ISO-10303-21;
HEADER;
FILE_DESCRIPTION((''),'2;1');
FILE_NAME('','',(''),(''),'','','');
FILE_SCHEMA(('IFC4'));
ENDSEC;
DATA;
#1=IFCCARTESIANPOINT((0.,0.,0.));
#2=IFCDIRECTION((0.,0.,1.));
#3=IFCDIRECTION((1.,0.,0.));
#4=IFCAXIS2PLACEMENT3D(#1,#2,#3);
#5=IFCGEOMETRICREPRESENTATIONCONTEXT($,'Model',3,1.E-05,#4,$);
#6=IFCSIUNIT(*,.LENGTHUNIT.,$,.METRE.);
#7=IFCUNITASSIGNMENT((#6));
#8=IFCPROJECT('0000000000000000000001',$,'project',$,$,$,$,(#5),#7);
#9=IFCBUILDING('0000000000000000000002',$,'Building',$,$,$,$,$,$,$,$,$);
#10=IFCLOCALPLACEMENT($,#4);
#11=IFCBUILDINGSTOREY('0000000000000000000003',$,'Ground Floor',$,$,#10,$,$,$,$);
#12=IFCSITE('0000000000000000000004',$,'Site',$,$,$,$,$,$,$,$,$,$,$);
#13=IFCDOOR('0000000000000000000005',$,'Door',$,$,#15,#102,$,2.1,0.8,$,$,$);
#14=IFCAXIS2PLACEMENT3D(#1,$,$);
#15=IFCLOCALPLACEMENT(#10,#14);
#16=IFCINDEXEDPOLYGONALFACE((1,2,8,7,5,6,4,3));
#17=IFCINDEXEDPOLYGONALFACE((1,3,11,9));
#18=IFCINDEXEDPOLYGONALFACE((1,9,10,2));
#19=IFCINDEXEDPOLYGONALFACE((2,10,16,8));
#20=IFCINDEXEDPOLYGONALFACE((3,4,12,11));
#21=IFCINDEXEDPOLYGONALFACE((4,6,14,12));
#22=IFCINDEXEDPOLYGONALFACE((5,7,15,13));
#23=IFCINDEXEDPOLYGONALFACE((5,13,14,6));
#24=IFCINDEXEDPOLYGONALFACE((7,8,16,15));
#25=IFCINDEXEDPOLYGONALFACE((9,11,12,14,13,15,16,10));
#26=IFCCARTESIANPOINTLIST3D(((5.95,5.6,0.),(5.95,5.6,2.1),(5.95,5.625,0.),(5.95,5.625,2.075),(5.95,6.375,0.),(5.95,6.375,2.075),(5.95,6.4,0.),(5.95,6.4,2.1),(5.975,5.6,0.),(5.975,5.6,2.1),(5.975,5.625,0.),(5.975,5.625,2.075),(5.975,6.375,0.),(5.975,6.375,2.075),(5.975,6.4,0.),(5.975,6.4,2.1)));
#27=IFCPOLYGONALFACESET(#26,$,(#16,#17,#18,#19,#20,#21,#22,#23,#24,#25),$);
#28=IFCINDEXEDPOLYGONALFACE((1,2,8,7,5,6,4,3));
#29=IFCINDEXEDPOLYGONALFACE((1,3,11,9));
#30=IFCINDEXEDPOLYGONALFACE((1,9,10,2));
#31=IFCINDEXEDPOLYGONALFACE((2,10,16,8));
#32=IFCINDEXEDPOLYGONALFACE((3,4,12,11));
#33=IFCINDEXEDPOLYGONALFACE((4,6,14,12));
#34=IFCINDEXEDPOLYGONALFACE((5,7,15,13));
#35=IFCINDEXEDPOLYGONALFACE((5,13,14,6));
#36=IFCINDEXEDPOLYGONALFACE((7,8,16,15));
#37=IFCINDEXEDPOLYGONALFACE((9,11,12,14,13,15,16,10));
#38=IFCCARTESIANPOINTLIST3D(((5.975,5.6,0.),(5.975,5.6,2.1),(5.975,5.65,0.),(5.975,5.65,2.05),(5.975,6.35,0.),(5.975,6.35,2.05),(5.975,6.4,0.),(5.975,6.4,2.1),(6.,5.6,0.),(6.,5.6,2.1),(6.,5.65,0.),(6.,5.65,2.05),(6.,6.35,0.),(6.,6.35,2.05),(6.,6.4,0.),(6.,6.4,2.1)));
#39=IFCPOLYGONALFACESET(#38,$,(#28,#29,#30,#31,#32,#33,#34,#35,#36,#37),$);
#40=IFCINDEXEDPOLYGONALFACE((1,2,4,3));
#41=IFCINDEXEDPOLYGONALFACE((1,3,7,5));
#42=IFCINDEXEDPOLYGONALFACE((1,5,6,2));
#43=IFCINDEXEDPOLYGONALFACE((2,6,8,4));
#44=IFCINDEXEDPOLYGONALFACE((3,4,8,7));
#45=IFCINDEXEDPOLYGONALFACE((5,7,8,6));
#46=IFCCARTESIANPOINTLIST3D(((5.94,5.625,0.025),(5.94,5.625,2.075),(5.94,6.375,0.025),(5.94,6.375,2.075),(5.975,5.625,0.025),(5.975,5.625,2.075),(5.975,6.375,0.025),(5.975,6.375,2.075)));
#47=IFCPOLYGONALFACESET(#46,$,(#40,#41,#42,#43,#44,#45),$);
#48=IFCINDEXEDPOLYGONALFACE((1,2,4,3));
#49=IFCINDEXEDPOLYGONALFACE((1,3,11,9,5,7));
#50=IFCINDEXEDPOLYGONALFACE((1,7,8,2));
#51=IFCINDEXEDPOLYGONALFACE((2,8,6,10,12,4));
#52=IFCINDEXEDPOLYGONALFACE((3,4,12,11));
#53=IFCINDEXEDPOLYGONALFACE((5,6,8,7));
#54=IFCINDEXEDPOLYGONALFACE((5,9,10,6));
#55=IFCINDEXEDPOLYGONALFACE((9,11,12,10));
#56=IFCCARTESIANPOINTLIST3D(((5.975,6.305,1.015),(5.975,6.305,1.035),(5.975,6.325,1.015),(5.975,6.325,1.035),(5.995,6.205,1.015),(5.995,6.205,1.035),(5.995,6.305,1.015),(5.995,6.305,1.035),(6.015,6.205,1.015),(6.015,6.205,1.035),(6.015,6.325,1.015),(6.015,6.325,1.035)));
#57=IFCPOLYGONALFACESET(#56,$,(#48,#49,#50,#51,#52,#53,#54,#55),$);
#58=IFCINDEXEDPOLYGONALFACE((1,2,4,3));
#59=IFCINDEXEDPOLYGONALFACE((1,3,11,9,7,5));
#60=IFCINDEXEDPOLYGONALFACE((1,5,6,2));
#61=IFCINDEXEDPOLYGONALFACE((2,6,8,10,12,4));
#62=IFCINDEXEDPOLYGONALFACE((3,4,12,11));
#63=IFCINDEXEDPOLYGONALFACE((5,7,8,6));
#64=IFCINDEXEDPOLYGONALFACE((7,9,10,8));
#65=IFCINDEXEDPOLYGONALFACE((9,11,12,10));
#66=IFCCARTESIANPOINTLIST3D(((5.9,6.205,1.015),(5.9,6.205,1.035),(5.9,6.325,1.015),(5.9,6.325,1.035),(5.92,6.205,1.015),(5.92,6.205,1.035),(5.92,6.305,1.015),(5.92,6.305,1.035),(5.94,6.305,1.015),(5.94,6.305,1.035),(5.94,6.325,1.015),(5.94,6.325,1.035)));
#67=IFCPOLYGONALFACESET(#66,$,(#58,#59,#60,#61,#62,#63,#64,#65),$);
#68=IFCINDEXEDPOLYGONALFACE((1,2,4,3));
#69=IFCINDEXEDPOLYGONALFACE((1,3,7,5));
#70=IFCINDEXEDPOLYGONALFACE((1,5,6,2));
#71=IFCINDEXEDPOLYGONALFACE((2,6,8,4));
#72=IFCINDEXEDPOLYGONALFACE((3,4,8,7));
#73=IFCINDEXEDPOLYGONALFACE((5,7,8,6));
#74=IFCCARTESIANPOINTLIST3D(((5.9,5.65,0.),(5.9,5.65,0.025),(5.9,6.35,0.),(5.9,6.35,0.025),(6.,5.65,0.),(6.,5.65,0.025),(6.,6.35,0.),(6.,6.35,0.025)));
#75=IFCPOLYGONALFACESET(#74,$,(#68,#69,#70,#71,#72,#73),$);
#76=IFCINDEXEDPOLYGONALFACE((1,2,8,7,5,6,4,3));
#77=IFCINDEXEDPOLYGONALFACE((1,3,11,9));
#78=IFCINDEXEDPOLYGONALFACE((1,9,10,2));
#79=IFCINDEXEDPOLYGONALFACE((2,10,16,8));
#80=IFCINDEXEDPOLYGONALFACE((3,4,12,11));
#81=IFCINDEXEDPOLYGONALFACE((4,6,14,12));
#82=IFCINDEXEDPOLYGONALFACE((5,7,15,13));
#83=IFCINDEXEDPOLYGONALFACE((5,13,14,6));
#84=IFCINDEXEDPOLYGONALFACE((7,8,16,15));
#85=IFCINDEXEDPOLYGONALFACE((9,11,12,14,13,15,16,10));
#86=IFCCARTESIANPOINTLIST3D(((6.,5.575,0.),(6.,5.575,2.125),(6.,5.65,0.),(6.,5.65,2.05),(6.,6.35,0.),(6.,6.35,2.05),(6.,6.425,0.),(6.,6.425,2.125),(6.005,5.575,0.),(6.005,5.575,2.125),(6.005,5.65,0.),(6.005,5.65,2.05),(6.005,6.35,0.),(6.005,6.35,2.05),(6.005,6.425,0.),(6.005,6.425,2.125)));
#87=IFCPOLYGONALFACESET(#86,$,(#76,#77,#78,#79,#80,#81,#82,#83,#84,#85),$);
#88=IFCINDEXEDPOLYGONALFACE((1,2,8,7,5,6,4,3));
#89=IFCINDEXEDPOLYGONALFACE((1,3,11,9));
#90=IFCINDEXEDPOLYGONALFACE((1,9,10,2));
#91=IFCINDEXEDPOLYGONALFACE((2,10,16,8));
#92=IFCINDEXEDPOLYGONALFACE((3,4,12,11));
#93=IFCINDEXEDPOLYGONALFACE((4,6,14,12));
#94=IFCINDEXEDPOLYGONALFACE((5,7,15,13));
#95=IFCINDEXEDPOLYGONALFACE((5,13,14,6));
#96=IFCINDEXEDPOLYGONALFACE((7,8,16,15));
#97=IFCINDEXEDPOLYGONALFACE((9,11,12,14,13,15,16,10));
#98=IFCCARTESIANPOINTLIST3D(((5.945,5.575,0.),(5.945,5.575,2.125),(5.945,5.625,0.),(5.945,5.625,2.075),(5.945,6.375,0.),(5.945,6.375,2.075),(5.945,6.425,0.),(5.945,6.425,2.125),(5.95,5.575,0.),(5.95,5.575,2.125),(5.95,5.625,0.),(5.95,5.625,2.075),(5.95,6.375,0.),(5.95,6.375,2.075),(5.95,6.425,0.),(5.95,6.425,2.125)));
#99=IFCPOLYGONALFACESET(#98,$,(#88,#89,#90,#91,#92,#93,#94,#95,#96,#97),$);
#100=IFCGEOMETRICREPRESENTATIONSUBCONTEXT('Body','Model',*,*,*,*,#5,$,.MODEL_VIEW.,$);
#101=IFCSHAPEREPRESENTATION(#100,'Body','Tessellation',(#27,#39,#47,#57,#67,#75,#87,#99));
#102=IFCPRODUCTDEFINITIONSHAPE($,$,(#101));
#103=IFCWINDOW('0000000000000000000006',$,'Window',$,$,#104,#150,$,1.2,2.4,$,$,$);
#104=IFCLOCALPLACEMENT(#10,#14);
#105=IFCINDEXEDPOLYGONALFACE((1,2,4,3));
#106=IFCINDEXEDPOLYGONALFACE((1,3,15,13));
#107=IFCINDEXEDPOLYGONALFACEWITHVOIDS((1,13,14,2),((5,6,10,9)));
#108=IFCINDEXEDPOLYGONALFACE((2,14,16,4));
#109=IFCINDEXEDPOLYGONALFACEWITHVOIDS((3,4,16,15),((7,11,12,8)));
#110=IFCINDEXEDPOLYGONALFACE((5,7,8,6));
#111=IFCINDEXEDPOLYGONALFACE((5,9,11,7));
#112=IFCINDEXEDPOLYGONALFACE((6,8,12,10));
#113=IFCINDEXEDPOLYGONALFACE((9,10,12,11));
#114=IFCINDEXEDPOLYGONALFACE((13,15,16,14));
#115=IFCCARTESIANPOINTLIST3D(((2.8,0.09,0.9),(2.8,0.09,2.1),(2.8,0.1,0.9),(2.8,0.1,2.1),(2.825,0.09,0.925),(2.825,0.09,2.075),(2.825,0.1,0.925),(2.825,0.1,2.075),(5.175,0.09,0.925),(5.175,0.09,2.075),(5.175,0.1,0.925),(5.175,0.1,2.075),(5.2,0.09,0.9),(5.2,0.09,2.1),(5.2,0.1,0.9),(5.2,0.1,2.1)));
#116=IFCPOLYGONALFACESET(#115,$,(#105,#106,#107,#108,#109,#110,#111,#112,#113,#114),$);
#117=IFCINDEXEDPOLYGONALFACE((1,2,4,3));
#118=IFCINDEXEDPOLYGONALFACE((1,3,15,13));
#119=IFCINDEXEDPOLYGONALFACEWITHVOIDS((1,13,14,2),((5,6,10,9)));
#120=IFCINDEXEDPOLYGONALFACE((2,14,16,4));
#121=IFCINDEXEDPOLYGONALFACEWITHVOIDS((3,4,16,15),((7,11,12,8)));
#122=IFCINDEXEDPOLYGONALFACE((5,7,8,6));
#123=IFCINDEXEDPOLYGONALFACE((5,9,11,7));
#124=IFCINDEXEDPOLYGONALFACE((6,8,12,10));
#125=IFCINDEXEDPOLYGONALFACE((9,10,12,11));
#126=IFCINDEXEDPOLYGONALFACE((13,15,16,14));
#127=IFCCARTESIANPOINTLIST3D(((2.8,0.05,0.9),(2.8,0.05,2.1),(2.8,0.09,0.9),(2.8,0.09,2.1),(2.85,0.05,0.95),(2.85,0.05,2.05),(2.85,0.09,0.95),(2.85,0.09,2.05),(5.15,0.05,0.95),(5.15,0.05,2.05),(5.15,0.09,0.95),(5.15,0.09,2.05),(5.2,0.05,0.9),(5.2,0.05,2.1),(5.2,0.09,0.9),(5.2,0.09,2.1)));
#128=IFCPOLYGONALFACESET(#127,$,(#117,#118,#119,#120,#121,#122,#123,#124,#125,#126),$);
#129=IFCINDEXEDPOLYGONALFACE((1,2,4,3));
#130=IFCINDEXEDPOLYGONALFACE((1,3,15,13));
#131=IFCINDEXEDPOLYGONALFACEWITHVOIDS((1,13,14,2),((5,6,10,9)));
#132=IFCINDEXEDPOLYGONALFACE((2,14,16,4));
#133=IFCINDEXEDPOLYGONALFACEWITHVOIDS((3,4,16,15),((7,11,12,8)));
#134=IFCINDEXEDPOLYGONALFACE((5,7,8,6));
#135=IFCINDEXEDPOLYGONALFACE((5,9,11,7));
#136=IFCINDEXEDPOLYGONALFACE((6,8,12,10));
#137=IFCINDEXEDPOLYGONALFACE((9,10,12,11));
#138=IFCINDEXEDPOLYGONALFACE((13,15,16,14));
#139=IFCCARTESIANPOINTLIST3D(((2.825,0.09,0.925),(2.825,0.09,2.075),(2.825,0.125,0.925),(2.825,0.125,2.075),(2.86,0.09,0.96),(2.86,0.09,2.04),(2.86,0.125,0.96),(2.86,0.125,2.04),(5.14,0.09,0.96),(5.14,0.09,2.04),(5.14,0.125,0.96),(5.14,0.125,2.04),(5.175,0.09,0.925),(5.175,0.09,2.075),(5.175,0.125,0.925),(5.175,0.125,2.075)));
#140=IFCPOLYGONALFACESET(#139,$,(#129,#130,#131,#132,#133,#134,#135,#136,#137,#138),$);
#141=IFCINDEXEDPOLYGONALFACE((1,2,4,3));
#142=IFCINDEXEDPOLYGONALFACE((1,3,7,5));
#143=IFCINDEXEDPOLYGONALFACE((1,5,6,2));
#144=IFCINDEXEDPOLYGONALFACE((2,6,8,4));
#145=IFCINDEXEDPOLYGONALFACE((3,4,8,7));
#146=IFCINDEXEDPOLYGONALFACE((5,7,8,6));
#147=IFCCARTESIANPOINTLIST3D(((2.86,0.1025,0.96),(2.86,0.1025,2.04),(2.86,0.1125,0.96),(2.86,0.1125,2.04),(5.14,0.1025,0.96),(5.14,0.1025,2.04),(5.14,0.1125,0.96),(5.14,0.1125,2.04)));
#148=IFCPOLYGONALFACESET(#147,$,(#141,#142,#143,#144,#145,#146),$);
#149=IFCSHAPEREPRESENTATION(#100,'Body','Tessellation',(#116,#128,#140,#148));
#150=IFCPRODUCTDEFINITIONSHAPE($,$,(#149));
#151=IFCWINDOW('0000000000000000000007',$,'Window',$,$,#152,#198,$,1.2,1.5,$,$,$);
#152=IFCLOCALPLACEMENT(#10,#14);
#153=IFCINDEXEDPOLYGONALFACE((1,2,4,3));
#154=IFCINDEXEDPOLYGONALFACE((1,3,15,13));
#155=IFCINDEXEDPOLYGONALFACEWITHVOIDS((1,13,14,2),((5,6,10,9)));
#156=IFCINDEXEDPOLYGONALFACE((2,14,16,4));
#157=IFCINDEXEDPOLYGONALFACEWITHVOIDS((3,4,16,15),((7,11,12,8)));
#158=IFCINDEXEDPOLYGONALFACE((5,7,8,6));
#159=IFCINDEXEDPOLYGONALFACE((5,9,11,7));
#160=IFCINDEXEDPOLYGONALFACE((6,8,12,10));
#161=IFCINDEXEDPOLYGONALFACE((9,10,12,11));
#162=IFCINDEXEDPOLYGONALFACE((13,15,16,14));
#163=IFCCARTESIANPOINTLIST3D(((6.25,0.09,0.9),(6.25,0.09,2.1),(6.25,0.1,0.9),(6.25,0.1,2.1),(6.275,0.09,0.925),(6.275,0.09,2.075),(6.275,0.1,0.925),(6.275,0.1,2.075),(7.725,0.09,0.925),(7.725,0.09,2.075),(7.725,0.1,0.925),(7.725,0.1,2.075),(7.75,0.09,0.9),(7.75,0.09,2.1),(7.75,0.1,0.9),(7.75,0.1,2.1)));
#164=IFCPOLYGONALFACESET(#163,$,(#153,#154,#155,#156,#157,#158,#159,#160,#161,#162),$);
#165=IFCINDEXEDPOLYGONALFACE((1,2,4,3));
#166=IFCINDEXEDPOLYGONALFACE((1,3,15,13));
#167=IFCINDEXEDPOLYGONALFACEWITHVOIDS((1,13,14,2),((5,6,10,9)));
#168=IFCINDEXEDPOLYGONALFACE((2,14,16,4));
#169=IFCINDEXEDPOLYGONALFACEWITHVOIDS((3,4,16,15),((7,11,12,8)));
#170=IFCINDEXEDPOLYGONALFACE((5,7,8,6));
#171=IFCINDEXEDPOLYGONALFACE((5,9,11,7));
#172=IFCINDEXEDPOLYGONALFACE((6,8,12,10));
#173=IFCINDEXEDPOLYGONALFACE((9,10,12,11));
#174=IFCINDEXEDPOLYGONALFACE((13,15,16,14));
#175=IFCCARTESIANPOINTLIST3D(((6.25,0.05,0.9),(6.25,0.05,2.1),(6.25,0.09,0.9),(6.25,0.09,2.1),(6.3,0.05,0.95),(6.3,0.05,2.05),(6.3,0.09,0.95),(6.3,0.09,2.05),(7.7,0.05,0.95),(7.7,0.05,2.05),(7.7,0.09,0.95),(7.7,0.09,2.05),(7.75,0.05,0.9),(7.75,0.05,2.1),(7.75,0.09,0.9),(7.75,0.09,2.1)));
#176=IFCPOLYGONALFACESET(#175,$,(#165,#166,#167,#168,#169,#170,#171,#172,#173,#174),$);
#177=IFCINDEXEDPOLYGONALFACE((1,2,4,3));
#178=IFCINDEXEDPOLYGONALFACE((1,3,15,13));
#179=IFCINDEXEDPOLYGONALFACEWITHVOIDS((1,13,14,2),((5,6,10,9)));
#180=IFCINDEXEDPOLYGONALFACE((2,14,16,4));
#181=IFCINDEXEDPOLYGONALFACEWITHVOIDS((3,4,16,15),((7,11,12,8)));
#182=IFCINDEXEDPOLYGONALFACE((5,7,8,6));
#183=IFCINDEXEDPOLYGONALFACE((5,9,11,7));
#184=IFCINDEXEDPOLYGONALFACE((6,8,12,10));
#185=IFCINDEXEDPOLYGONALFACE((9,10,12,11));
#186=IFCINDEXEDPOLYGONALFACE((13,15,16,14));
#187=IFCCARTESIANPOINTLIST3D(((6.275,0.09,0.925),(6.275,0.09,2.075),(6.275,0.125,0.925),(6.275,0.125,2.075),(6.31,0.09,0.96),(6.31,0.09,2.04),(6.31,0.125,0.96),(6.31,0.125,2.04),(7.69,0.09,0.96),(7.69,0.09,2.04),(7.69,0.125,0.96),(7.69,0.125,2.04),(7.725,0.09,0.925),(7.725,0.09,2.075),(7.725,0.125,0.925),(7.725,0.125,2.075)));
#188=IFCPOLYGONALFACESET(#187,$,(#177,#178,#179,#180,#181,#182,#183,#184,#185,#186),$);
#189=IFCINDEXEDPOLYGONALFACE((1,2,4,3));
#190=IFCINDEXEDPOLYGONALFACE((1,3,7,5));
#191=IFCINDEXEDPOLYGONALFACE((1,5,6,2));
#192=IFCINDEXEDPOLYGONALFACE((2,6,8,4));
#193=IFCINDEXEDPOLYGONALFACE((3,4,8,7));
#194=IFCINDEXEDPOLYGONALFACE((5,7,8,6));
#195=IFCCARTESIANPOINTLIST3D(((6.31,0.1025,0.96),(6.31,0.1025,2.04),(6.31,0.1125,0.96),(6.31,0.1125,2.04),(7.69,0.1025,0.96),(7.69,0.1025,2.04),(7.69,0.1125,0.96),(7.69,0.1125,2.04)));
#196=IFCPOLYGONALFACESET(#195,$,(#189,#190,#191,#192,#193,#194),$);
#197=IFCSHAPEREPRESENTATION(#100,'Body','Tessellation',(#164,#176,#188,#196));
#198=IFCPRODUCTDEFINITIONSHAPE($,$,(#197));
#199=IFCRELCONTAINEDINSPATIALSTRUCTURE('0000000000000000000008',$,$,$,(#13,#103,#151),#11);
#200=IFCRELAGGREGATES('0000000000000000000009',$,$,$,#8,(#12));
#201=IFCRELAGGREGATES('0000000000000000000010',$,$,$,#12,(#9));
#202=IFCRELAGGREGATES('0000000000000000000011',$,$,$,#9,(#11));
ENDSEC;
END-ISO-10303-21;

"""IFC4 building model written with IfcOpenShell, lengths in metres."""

from ifc_helpers import new_model, si_unit, frame, origin_with_axes, place, context, subcontext, project, spatial, line, indexed_curve, outline, extrude, element, save


model = new_model("IFC4")

# Units and contexts
model_context = context("Model", 3, precision=1e-05, world=origin_with_axes())
body_context = subcontext(model_context, "Body", "Model", "MODEL_VIEW")
ifc_project = project(units=[si_unit("LENGTHUNIT", "METRE")], contexts=[model_context])

# Site, building, storey
site = spatial("IfcSite", under=ifc_project, Name="Site")
building = spatial("IfcBuilding", under=site, Name="Building")
storey_placement = place(None, origin_with_axes())
storey = spatial("IfcBuildingStorey", under=building, at=storey_placement, Name="Ground Floor")

# Door
door_1_placement = place(storey_placement, frame((6.0, 5.6, 0.0), z_axis=(0.0, 0.0, 1.0), x_axis=(0.0, 1.0, 0.0)))
element("IfcDoor", 1, at=door_1_placement, inside=storey, Name="Door", OverallHeight=2.1, OverallWidth=0.8, context=body_context, shape_type="SweptSolid", body=[
    extrude(outline(indexed_curve([(0.0, 0.0), (0.0, 2.1), (0.8, 2.1), (0.8, 0.0), (0.775, 0.0), (0.775, 2.075), (0.025, 2.075), (0.025, 0.0)], segments=[line(1, 2, 3, 4, 5, 6, 7, 8, 1)])), frame((0.0, 0.025, 0.0), z_axis=(0.0, -1.0, 0.0), x_axis=(1.0, 0.0, 0.0)), (0.0, 0.0, -1.0), 0.025),
    extrude(outline(indexed_curve([(0.0, 0.0), (0.0, 2.1), (0.8, 2.1), (0.8, 0.0), (0.75, 0.0), (0.75, 2.05), (0.05, 2.05), (0.05, 0.0)], segments=[line(1, 2, 3, 4, 5, 6, 7, 8, 1)])), frame((0.0, 0.0, 0.0), z_axis=(0.0, -1.0, 0.0), x_axis=(1.0, 0.0, 0.0)), (0.0, 0.0, -1.0), 0.025),
    extrude(outline(indexed_curve([(0.0, 0.0), (0.75, 0.0), (0.75, 0.035), (0.0, 0.035)], segments=[line(1, 2, 3, 4, 1)])), frame((0.025, 0.025, 0.025), z_axis=(0.0, 0.0, 1.0), x_axis=(1.0, 0.0, 0.0)), (0.0, 0.0, 1.0), 2.05),
    extrude(outline(indexed_curve([(0.0, 0.0), (0.0, -0.04), (-0.12, -0.04), (-0.12, -0.02), (-0.02, -0.02), (-0.02, 0.0)], segments=[line(1, 2, 3, 4, 5, 6, 1)])), frame((0.725, 0.025, 1.015), z_axis=(0.0, 0.0, 1.0), x_axis=(1.0, 0.0, 0.0)), (0.0, 0.0, 1.0), 0.02),
    extrude(outline(indexed_curve([(0.0, 0.0), (0.0, 0.04), (-0.12, 0.04), (-0.12, 0.02), (-0.02, 0.02), (-0.02, 0.0)], segments=[line(1, 2, 3, 4, 5, 6, 1)])), frame((0.725, 0.06, 1.015), z_axis=(0.0, 0.0, 1.0), x_axis=(1.0, 0.0, 0.0)), (0.0, 0.0, 1.0), 0.02),
    extrude(outline(indexed_curve([(0.0, 0.0), (0.7, 0.0), (0.7, 0.1), (0.0, 0.1)], segments=[line(1, 2, 3, 4, 1)])), frame((0.05, 0.0, 0.0), z_axis=(0.0, 0.0, 1.0), x_axis=(1.0, 0.0, 0.0)), (0.0, 0.0, 1.0), 0.025),
    extrude(outline(indexed_curve([(0.0, 0.0), (0.0, 2.125), (0.85, 2.125), (0.85, 0.0), (0.775, 0.0), (0.775, 2.05), (0.075, 2.05), (0.075, 0.0)], segments=[line(1, 2, 3, 4, 5, 6, 7, 8, 1)])), frame((-0.025, -0.005, 0.0), z_axis=(0.0, -1.0, 0.0), x_axis=(1.0, 0.0, 0.0)), (0.0, 0.0, -1.0), 0.005),
    extrude(outline(indexed_curve([(0.0, 0.0), (0.0, 2.125), (0.85, 2.125), (0.85, 0.0), (0.8, 0.0), (0.8, 2.075), (0.05, 2.075), (0.05, 0.0)], segments=[line(1, 2, 3, 4, 5, 6, 7, 8, 1)])), frame((-0.025, 0.05, 0.0), z_axis=(0.0, -1.0, 0.0), x_axis=(1.0, 0.0, 0.0)), (0.0, 0.0, -1.0), 0.005),
])

# Windows
window_1_placement = place(storey_placement, frame((2.8, 0.0, 0.9), z_axis=(0.0, 0.0, 1.0), x_axis=(1.0, 0.0, 0.0)))
element("IfcWindow", 2, at=window_1_placement, inside=storey, Name="Window", OverallHeight=1.2, OverallWidth=2.4, context=body_context, shape_type="SweptSolid", body=[
    extrude(outline(indexed_curve([(0.0, 0.0), (2.4, 0.0), (2.4, 1.2), (0.0, 1.2)], segments=[line(1, 2, 3, 4, 1)]), holes=[indexed_curve([(0.025, 0.025), (2.375, 0.025), (2.375, 1.175), (0.025, 1.175)], segments=[line(1, 2, 3, 4, 1)])]), frame((0.0, 0.09, 0.0), z_axis=(0.0, -1.0, 0.0), x_axis=(1.0, 0.0, 0.0)), (0.0, 0.0, -1.0), 0.01),
    extrude(outline(indexed_curve([(0.0, 0.0), (2.4, 0.0), (2.4, 1.2), (0.0, 1.2)], segments=[line(1, 2, 3, 4, 1)]), holes=[indexed_curve([(0.05, 0.05), (2.35, 0.05), (2.35, 1.15), (0.05, 1.15)], segments=[line(1, 2, 3, 4, 1)])]), frame((0.0, 0.05, 0.0), z_axis=(0.0, -1.0, 0.0), x_axis=(1.0, 0.0, 0.0)), (0.0, 0.0, -1.0), 0.04),
    extrude(outline(indexed_curve([(0.0, 0.0), (2.35, 0.0), (2.35, 1.15), (0.0, 1.15)], segments=[line(1, 2, 3, 4, 1)]), holes=[indexed_curve([(0.035, 0.035), (2.315, 0.035), (2.315, 1.115), (0.035, 1.115)], segments=[line(1, 2, 3, 4, 1)])]), frame((0.025, 0.09, 0.025), z_axis=(0.0, -1.0, 0.0), x_axis=(1.0, 0.0, 0.0)), (0.0, 0.0, -1.0), 0.035),
    extrude(outline(indexed_curve([(0.035, 0.035), (2.315, 0.035), (2.315, 1.115), (0.035, 1.115)], segments=[line(1, 2, 3, 4, 1)])), frame((0.025, 0.1025, 0.025), z_axis=(0.0, -1.0, 0.0), x_axis=(1.0, 0.0, 0.0)), (0.0, 0.0, -1.0), 0.01),
])
window_2_placement = place(storey_placement, frame((6.25, 0.0, 0.9), z_axis=(0.0, 0.0, 1.0), x_axis=(1.0, 0.0, 0.0)))
element("IfcWindow", 3, at=window_2_placement, inside=storey, Name="Window", OverallHeight=1.2, OverallWidth=1.5, context=body_context, shape_type="SweptSolid", body=[
    extrude(outline(indexed_curve([(0.0, 0.0), (1.5, 0.0), (1.5, 1.2), (0.0, 1.2)], segments=[line(1, 2, 3, 4, 1)]), holes=[indexed_curve([(0.025, 0.025), (1.475, 0.025), (1.475, 1.175), (0.025, 1.175)], segments=[line(1, 2, 3, 4, 1)])]), frame((0.0, 0.09, 0.0), z_axis=(0.0, -1.0, 0.0), x_axis=(1.0, 0.0, 0.0)), (0.0, 0.0, -1.0), 0.01),
    extrude(outline(indexed_curve([(0.0, 0.0), (1.5, 0.0), (1.5, 1.2), (0.0, 1.2)], segments=[line(1, 2, 3, 4, 1)]), holes=[indexed_curve([(0.05, 0.05), (1.45, 0.05), (1.45, 1.15), (0.05, 1.15)], segments=[line(1, 2, 3, 4, 1)])]), frame((0.0, 0.05, 0.0), z_axis=(0.0, -1.0, 0.0), x_axis=(1.0, 0.0, 0.0)), (0.0, 0.0, -1.0), 0.04),
    extrude(outline(indexed_curve([(0.0, 0.0), (1.45, 0.0), (1.45, 1.15), (0.0, 1.15)], segments=[line(1, 2, 3, 4, 1)]), holes=[indexed_curve([(0.035, 0.035), (1.415, 0.035), (1.415, 1.115), (0.035, 1.115)], segments=[line(1, 2, 3, 4, 1)])]), frame((0.025, 0.09, 0.025), z_axis=(0.0, -1.0, 0.0), x_axis=(1.0, 0.0, 0.0)), (0.0, 0.0, -1.0), 0.035),
    extrude(outline(indexed_curve([(0.035, 0.035), (1.415, 0.035), (1.415, 1.115), (0.035, 1.115)], segments=[line(1, 2, 3, 4, 1)])), frame((0.025, 0.1025, 0.025), z_axis=(0.0, -1.0, 0.0), x_axis=(1.0, 0.0, 0.0)), (0.0, 0.0, -1.0), 0.01),
])

save(model, "model.ifc")
